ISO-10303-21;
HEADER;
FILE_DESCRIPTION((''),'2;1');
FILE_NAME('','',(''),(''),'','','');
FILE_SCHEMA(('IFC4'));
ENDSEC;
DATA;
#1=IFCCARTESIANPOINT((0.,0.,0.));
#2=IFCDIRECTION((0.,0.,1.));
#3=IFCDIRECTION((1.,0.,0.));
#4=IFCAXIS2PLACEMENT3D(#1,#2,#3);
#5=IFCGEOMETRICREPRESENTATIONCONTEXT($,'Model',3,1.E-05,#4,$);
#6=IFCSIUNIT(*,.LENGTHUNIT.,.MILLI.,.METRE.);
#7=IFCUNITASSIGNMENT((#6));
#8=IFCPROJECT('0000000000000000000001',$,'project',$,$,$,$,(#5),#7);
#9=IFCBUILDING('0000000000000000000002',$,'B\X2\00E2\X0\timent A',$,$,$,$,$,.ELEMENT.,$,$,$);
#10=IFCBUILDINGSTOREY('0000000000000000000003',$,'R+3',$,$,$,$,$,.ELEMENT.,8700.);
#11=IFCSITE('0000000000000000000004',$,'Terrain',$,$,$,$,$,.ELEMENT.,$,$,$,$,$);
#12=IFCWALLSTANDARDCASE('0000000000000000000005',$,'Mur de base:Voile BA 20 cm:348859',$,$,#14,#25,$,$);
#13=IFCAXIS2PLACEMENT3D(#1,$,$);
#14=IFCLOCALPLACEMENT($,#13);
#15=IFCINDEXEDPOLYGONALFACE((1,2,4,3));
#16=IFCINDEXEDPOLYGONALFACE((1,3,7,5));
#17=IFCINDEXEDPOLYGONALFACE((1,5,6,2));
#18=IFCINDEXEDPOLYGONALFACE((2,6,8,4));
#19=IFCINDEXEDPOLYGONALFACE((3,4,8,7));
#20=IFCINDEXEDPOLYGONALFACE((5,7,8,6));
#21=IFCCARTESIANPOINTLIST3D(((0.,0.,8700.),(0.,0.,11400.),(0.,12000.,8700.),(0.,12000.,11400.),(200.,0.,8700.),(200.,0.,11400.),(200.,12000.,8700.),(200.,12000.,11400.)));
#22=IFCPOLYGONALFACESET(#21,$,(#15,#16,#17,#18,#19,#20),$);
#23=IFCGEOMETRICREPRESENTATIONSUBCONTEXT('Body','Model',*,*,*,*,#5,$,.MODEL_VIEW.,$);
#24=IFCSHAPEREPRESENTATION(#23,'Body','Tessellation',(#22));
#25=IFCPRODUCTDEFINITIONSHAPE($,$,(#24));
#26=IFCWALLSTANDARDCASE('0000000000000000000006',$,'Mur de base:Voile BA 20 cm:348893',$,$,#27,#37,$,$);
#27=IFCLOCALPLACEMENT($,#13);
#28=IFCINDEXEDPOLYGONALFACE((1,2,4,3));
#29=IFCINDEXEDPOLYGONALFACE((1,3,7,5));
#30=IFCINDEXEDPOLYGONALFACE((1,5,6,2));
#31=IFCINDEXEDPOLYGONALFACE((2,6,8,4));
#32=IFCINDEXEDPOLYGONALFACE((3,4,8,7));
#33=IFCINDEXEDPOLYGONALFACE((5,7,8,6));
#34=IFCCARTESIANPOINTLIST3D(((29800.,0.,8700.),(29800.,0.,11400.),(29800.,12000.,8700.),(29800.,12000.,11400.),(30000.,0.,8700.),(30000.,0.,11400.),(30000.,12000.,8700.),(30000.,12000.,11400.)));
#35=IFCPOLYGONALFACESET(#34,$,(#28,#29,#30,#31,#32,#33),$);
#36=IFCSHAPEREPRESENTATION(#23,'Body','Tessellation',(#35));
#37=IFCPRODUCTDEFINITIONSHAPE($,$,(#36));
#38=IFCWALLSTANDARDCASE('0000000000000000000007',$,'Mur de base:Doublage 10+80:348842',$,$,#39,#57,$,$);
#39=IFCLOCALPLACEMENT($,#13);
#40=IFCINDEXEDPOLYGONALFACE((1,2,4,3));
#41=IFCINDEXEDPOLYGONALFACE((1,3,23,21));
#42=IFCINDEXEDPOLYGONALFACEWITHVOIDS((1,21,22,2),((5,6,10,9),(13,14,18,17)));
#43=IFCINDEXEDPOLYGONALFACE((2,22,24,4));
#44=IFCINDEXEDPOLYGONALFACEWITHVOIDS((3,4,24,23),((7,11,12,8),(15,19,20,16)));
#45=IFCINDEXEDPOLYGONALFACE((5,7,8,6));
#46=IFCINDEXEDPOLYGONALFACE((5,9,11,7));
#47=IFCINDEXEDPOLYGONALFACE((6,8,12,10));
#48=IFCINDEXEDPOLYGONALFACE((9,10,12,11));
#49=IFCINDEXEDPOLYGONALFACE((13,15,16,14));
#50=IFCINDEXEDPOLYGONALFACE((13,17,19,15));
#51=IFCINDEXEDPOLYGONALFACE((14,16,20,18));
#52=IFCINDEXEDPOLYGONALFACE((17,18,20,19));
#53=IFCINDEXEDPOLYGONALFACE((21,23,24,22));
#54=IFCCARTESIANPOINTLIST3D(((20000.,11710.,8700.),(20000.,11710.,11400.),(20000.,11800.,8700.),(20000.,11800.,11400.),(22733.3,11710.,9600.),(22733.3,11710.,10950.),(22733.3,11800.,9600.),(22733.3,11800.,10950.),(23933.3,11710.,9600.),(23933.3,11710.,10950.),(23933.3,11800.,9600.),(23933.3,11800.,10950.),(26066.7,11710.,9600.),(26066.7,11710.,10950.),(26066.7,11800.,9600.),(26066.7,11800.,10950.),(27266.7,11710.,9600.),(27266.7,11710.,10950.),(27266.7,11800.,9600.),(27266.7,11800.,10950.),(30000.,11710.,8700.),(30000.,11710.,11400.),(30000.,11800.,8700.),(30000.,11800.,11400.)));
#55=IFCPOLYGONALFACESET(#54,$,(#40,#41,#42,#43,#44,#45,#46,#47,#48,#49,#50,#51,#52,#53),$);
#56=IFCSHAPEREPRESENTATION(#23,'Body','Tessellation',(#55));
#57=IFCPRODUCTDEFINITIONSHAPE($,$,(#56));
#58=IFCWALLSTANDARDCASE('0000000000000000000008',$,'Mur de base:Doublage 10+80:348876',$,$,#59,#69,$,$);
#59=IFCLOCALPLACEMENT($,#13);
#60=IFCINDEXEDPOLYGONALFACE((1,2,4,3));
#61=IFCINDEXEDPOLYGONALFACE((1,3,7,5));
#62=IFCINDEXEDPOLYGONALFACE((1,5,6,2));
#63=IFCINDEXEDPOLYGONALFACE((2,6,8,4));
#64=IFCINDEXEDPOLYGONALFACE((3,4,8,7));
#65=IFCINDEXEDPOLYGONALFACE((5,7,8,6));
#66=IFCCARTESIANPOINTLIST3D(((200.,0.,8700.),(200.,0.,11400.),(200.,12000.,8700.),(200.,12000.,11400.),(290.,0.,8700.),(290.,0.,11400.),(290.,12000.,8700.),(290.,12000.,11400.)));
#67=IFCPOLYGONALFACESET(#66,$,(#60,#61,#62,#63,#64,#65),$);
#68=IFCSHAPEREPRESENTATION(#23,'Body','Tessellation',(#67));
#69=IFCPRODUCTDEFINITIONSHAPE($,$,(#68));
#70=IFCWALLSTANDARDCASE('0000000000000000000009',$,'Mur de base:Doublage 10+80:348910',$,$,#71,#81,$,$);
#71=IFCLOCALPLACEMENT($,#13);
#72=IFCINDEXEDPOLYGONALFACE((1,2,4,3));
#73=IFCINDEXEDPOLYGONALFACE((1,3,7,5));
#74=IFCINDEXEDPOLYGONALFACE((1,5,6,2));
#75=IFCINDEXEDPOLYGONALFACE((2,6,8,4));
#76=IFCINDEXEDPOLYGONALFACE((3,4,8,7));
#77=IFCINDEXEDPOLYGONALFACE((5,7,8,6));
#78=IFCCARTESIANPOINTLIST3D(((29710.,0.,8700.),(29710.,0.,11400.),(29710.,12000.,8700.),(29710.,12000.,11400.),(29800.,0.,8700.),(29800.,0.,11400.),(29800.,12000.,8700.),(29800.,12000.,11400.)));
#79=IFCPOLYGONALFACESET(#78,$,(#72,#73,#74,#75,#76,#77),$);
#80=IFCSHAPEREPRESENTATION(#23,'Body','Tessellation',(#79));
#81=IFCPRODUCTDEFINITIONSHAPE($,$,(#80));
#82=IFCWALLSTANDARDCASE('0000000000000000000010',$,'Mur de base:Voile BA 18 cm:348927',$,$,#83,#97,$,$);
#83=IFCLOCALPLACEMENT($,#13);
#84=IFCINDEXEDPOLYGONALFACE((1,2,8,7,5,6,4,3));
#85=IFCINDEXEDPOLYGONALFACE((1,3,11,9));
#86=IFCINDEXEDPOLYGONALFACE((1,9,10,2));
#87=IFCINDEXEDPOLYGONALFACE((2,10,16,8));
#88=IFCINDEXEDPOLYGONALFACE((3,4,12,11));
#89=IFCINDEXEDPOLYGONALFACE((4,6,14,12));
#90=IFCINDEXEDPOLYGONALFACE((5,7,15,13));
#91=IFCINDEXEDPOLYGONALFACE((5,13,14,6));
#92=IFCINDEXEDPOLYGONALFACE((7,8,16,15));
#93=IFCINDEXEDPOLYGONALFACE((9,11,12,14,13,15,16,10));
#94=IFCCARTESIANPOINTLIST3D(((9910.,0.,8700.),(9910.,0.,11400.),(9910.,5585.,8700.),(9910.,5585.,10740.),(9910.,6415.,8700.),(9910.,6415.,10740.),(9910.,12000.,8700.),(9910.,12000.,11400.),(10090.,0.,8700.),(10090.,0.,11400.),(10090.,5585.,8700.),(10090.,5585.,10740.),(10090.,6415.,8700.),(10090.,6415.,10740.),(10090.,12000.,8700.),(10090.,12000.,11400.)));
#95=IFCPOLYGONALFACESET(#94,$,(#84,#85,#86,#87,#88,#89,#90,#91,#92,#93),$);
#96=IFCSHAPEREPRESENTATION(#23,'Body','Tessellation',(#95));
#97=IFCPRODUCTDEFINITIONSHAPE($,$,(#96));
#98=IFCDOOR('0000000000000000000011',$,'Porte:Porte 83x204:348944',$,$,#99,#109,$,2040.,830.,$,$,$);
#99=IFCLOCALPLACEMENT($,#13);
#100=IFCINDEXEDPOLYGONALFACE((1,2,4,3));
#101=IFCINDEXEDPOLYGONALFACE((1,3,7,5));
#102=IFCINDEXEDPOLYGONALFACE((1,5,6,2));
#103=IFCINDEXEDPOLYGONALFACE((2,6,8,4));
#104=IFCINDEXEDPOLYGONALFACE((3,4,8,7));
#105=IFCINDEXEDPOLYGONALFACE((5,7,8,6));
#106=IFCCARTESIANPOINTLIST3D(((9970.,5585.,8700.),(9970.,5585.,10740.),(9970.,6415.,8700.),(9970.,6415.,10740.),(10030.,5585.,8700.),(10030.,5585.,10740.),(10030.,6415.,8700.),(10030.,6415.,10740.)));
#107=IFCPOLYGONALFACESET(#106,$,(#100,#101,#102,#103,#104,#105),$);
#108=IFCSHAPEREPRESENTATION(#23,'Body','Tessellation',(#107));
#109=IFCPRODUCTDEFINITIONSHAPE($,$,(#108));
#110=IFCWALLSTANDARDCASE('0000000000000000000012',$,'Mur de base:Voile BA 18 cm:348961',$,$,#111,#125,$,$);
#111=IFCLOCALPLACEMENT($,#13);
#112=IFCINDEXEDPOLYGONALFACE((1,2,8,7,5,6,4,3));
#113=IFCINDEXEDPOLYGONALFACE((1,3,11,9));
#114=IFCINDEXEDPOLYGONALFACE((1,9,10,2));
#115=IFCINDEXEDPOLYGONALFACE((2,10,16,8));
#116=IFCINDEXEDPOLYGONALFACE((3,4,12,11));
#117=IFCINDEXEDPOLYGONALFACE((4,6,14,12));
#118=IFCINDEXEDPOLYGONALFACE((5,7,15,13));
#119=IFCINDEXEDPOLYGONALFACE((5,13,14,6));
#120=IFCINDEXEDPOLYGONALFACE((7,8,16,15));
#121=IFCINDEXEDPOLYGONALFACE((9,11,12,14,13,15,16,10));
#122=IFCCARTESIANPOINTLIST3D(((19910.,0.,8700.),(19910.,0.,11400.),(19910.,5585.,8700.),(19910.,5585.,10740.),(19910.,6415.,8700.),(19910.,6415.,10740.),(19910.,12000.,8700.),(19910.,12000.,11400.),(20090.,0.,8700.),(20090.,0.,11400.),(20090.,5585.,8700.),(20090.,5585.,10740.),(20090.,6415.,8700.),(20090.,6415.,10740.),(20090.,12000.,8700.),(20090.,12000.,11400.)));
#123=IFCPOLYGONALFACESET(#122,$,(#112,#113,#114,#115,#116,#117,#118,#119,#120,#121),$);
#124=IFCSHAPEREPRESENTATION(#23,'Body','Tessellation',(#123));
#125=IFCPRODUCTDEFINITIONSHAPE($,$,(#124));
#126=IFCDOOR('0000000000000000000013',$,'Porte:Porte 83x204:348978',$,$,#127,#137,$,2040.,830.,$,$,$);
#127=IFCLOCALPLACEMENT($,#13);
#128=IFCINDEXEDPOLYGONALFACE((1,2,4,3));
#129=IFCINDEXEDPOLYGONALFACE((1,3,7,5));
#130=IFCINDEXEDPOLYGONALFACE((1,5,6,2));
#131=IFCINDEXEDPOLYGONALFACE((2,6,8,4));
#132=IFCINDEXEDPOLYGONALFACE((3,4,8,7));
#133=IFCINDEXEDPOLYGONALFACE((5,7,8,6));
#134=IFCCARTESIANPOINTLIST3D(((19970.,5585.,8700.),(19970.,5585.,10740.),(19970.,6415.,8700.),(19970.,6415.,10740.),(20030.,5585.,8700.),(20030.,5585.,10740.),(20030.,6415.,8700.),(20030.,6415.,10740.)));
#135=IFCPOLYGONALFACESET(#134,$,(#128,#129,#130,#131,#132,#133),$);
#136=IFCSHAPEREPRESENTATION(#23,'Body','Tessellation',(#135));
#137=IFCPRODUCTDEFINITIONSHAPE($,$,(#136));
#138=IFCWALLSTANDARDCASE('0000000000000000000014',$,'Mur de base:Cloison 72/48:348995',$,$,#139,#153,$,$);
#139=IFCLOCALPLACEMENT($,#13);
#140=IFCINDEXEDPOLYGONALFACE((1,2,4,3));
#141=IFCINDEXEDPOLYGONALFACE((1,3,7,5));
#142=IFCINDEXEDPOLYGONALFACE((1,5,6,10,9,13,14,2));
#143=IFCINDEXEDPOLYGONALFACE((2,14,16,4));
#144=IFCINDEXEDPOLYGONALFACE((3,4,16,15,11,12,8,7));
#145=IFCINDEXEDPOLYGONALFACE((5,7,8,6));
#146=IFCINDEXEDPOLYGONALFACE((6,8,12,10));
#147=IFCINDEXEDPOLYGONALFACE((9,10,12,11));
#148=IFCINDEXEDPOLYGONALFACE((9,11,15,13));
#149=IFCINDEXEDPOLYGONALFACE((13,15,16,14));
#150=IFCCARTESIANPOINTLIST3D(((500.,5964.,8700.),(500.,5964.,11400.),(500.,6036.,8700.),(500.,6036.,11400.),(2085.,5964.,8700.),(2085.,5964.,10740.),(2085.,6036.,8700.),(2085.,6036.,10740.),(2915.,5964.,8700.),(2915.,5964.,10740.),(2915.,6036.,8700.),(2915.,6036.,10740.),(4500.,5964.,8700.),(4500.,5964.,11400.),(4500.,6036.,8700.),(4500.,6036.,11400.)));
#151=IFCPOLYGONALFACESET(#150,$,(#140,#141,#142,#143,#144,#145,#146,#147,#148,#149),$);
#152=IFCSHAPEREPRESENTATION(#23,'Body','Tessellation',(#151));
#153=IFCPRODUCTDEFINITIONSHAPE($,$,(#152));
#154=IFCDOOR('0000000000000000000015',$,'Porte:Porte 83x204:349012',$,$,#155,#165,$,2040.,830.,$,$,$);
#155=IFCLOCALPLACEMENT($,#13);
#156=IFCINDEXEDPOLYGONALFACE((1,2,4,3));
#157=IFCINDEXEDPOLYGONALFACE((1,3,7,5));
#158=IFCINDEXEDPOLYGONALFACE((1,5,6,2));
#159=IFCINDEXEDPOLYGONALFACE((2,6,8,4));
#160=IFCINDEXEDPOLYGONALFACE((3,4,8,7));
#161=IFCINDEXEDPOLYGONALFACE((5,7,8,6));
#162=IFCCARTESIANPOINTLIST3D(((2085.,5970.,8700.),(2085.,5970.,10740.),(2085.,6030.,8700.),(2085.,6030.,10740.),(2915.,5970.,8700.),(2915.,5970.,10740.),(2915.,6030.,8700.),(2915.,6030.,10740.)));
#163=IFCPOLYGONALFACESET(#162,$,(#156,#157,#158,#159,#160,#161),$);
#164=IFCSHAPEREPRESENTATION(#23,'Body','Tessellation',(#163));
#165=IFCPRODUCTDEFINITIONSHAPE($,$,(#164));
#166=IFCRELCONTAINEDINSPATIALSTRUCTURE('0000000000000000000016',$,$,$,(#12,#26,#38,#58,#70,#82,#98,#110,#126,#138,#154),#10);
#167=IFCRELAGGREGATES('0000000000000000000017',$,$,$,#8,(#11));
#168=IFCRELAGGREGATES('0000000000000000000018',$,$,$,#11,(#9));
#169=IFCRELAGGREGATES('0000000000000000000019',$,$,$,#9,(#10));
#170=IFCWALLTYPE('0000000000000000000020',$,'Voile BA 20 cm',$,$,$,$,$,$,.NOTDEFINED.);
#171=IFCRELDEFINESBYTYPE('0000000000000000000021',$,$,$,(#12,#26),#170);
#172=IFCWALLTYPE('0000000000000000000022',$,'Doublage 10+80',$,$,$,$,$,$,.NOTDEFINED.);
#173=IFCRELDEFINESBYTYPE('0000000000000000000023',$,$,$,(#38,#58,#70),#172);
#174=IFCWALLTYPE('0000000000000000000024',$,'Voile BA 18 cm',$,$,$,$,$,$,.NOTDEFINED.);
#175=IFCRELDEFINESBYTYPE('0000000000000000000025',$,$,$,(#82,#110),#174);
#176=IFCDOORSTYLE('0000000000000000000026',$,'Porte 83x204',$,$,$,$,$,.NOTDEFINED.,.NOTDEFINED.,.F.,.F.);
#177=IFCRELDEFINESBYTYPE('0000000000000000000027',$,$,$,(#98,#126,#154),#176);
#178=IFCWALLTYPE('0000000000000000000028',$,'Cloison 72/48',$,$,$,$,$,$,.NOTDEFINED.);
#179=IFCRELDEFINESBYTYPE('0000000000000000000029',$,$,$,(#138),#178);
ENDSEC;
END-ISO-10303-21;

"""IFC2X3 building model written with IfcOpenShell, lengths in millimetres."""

from ifc_helpers import new_model, si_unit, frame, frame_2d, origin_with_axes, place, context, subcontext, project, spatial, rectangle, extrude, type_object, element, fill, save


model = new_model("IFC2X3")

# Units and contexts
model_context = context("Model", 3, precision=1e-05, world=origin_with_axes())
body_context = subcontext(model_context, "Body", "Model", "MODEL_VIEW")
ifc_project = project(units=[si_unit("LENGTHUNIT", "METRE", prefix="MILLI")], contexts=[model_context])

# Site, building, storey
site = spatial("IfcSite", under=ifc_project, Name="Terrain", CompositionType="ELEMENT")
building = spatial("IfcBuilding", under=site, Name="Bâtiment A", CompositionType="ELEMENT")
storey = spatial("IfcBuildingStorey", under=building, Name="R+3", CompositionType="ELEMENT", Elevation=8700.0)

# Walls
wall_type_1 = type_object("IfcWallType", Name="Voile BA 20 cm", PredefinedType="NOTDEFINED")
wall_1_placement = place(None, origin_with_axes())
element("IfcWallStandardCase", 1, at=wall_1_placement, inside=storey, type_object=wall_type_1, Name="Mur de base:Voile BA 20 cm:348859", context=body_context, shape_type="SweptSolid", body=[
    extrude(rectangle(XDim=200.0, YDim=12000.0, at=frame_2d((100.0, 6000.0))), frame((0.0, 0.0, 8700.0), z_axis=(0.0, 0.0, 1.0), x_axis=(1.0, 0.0, 0.0)), (0.0, 0.0, 1.0), 2700.0),
])
wall_2_placement = place(None, origin_with_axes())
element("IfcWallStandardCase", 2, at=wall_2_placement, inside=storey, type_object=wall_type_1, Name="Mur de base:Voile BA 20 cm:348893", context=body_context, shape_type="SweptSolid", body=[
    extrude(rectangle(XDim=200.0, YDim=12000.0, at=frame_2d((29900.0, 6000.0))), frame((0.0, 0.0, 8700.0), z_axis=(0.0, 0.0, 1.0), x_axis=(1.0, 0.0, 0.0)), (0.0, 0.0, 1.0), 2700.0),
])

# Wall, openings
wall_type_2 = type_object("IfcWallType", Name="Doublage 10+80", PredefinedType="NOTDEFINED")
wall_3_placement = place(None, origin_with_axes())
wall_3 = element("IfcWallStandardCase", 3, at=wall_3_placement, inside=storey, type_object=wall_type_2, Name="Mur de base:Doublage 10+80:348842", context=body_context, shape_type="SweptSolid", body=[
    extrude(rectangle(XDim=10000.0, YDim=90.0, at=frame_2d((25000.0, 11755.0))), frame((0.0, 0.0, 8700.0), z_axis=(0.0, 0.0, 1.0), x_axis=(1.0, 0.0, 0.0)), (0.0, 0.0, 1.0), 2700.0),
])
opening_1_placement = place(None, origin_with_axes())
element("IfcOpeningElement", 4, at=opening_1_placement, cuts=wall_3, context=body_context, shape_type="SweptSolid", body=[
    extrude(rectangle(XDim=1200.0, YDim=210.0, at=frame_2d((23333.3, 11755.0))), frame((0.0, 0.0, 9600.0), z_axis=(0.0, 0.0, 1.0), x_axis=(1.0, 0.0, 0.0)), (0.0, 0.0, 1.0), 1350.0),
])
opening_2_placement = place(None, origin_with_axes())
element("IfcOpeningElement", 5, at=opening_2_placement, cuts=wall_3, context=body_context, shape_type="SweptSolid", body=[
    extrude(rectangle(XDim=1200.0, YDim=210.0, at=frame_2d((26666.7, 11755.0))), frame((0.0, 0.0, 9600.0), z_axis=(0.0, 0.0, 1.0), x_axis=(1.0, 0.0, 0.0)), (0.0, 0.0, 1.0), 1350.0),
])

# Walls
wall_4_placement = place(None, origin_with_axes())
element("IfcWallStandardCase", 6, at=wall_4_placement, inside=storey, type_object=wall_type_2, Name="Mur de base:Doublage 10+80:348876", context=body_context, shape_type="SweptSolid", body=[
    extrude(rectangle(XDim=90.0, YDim=12000.0, at=frame_2d((245.0, 6000.0))), frame((0.0, 0.0, 8700.0), z_axis=(0.0, 0.0, 1.0), x_axis=(1.0, 0.0, 0.0)), (0.0, 0.0, 1.0), 2700.0),
])
wall_5_placement = place(None, origin_with_axes())
element("IfcWallStandardCase", 7, at=wall_5_placement, inside=storey, type_object=wall_type_2, Name="Mur de base:Doublage 10+80:348910", context=body_context, shape_type="SweptSolid", body=[
    extrude(rectangle(XDim=90.0, YDim=12000.0, at=frame_2d((29755.0, 6000.0))), frame((0.0, 0.0, 8700.0), z_axis=(0.0, 0.0, 1.0), x_axis=(1.0, 0.0, 0.0)), (0.0, 0.0, 1.0), 2700.0),
])

# Walls, openings, doors
wall_type_3 = type_object("IfcWallType", Name="Voile BA 18 cm", PredefinedType="NOTDEFINED")
wall_6_placement = place(None, origin_with_axes())
wall_6 = element("IfcWallStandardCase", 8, at=wall_6_placement, inside=storey, type_object=wall_type_3, Name="Mur de base:Voile BA 18 cm:348927", context=body_context, shape_type="SweptSolid", body=[
    extrude(rectangle(XDim=180.0, YDim=12000.0, at=frame_2d((10000.0, 6000.0))), frame((0.0, 0.0, 8700.0), z_axis=(0.0, 0.0, 1.0), x_axis=(1.0, 0.0, 0.0)), (0.0, 0.0, 1.0), 2700.0),
])
opening_3_placement = place(None, origin_with_axes())
opening_3 = element("IfcOpeningElement", 9, at=opening_3_placement, cuts=wall_6, context=body_context, shape_type="SweptSolid", body=[
    extrude(rectangle(XDim=300.0, YDim=830.0, at=frame_2d((10000.0, 6000.0))), frame((0.0, 0.0, 8700.0), z_axis=(0.0, 0.0, 1.0), x_axis=(1.0, 0.0, 0.0)), (0.0, 0.0, 1.0), 2040.0),
])
door_style = type_object("IfcDoorStyle", Name="Porte 83x204", ConstructionType="NOTDEFINED", OperationType="NOTDEFINED", ParameterTakesPrecedence=False, Sizeable=False)
door_1_placement = place(None, origin_with_axes())
door_1 = element("IfcDoor", 10, at=door_1_placement, inside=storey, type_object=door_style, Name="Porte:Porte 83x204:348944", OverallHeight=2040.0, OverallWidth=830.0, context=body_context, shape_type="SweptSolid", body=[
    extrude(rectangle(XDim=60.0, YDim=830.0, at=frame_2d((10000.0, 6000.0))), frame((0.0, 0.0, 8700.0), z_axis=(0.0, 0.0, 1.0), x_axis=(1.0, 0.0, 0.0)), (0.0, 0.0, 1.0), 2040.0),
])
fill(opening_3, door_1)
wall_7_placement = place(None, origin_with_axes())
wall_7 = element("IfcWallStandardCase", 11, at=wall_7_placement, inside=storey, type_object=wall_type_3, Name="Mur de base:Voile BA 18 cm:348961", context=body_context, shape_type="SweptSolid", body=[
    extrude(rectangle(XDim=180.0, YDim=12000.0, at=frame_2d((20000.0, 6000.0))), frame((0.0, 0.0, 8700.0), z_axis=(0.0, 0.0, 1.0), x_axis=(1.0, 0.0, 0.0)), (0.0, 0.0, 1.0), 2700.0),
])
opening_4_placement = place(None, origin_with_axes())
opening_4 = element("IfcOpeningElement", 12, at=opening_4_placement, cuts=wall_7, context=body_context, shape_type="SweptSolid", body=[
    extrude(rectangle(XDim=300.0, YDim=830.0, at=frame_2d((20000.0, 6000.0))), frame((0.0, 0.0, 8700.0), z_axis=(0.0, 0.0, 1.0), x_axis=(1.0, 0.0, 0.0)), (0.0, 0.0, 1.0), 2040.0),
])
door_2_placement = place(None, origin_with_axes())
door_2 = element("IfcDoor", 13, at=door_2_placement, inside=storey, type_object=door_style, Name="Porte:Porte 83x204:348978", OverallHeight=2040.0, OverallWidth=830.0, context=body_context, shape_type="SweptSolid", body=[
    extrude(rectangle(XDim=60.0, YDim=830.0, at=frame_2d((20000.0, 6000.0))), frame((0.0, 0.0, 8700.0), z_axis=(0.0, 0.0, 1.0), x_axis=(1.0, 0.0, 0.0)), (0.0, 0.0, 1.0), 2040.0),
])
fill(opening_4, door_2)
wall_type_4 = type_object("IfcWallType", Name="Cloison 72/48", PredefinedType="NOTDEFINED")
wall_8_placement = place(None, origin_with_axes())
wall_8 = element("IfcWallStandardCase", 14, at=wall_8_placement, inside=storey, type_object=wall_type_4, Name="Mur de base:Cloison 72/48:348995", context=body_context, shape_type="SweptSolid", body=[
    extrude(rectangle(XDim=4000.0, YDim=72.0, at=frame_2d((2500.0, 6000.0))), frame((0.0, 0.0, 8700.0), z_axis=(0.0, 0.0, 1.0), x_axis=(1.0, 0.0, 0.0)), (0.0, 0.0, 1.0), 2700.0),
])
opening_5_placement = place(None, origin_with_axes())
opening_5 = element("IfcOpeningElement", 15, at=opening_5_placement, cuts=wall_8, context=body_context, shape_type="SweptSolid", body=[
    extrude(rectangle(XDim=830.0, YDim=192.0, at=frame_2d((2500.0, 6000.0))), frame((0.0, 0.0, 8700.0), z_axis=(0.0, 0.0, 1.0), x_axis=(1.0, 0.0, 0.0)), (0.0, 0.0, 1.0), 2040.0),
])
door_3_placement = place(None, origin_with_axes())
door_3 = element("IfcDoor", 16, at=door_3_placement, inside=storey, type_object=door_style, Name="Porte:Porte 83x204:349012", OverallHeight=2040.0, OverallWidth=830.0, context=body_context, shape_type="SweptSolid", body=[
    extrude(rectangle(XDim=830.0, YDim=60.0, at=frame_2d((2500.0, 6000.0))), frame((0.0, 0.0, 8700.0), z_axis=(0.0, 0.0, 1.0), x_axis=(1.0, 0.0, 0.0)), (0.0, 0.0, 1.0), 2040.0),
])
fill(opening_5, door_3)

save(model, "model.ifc")
